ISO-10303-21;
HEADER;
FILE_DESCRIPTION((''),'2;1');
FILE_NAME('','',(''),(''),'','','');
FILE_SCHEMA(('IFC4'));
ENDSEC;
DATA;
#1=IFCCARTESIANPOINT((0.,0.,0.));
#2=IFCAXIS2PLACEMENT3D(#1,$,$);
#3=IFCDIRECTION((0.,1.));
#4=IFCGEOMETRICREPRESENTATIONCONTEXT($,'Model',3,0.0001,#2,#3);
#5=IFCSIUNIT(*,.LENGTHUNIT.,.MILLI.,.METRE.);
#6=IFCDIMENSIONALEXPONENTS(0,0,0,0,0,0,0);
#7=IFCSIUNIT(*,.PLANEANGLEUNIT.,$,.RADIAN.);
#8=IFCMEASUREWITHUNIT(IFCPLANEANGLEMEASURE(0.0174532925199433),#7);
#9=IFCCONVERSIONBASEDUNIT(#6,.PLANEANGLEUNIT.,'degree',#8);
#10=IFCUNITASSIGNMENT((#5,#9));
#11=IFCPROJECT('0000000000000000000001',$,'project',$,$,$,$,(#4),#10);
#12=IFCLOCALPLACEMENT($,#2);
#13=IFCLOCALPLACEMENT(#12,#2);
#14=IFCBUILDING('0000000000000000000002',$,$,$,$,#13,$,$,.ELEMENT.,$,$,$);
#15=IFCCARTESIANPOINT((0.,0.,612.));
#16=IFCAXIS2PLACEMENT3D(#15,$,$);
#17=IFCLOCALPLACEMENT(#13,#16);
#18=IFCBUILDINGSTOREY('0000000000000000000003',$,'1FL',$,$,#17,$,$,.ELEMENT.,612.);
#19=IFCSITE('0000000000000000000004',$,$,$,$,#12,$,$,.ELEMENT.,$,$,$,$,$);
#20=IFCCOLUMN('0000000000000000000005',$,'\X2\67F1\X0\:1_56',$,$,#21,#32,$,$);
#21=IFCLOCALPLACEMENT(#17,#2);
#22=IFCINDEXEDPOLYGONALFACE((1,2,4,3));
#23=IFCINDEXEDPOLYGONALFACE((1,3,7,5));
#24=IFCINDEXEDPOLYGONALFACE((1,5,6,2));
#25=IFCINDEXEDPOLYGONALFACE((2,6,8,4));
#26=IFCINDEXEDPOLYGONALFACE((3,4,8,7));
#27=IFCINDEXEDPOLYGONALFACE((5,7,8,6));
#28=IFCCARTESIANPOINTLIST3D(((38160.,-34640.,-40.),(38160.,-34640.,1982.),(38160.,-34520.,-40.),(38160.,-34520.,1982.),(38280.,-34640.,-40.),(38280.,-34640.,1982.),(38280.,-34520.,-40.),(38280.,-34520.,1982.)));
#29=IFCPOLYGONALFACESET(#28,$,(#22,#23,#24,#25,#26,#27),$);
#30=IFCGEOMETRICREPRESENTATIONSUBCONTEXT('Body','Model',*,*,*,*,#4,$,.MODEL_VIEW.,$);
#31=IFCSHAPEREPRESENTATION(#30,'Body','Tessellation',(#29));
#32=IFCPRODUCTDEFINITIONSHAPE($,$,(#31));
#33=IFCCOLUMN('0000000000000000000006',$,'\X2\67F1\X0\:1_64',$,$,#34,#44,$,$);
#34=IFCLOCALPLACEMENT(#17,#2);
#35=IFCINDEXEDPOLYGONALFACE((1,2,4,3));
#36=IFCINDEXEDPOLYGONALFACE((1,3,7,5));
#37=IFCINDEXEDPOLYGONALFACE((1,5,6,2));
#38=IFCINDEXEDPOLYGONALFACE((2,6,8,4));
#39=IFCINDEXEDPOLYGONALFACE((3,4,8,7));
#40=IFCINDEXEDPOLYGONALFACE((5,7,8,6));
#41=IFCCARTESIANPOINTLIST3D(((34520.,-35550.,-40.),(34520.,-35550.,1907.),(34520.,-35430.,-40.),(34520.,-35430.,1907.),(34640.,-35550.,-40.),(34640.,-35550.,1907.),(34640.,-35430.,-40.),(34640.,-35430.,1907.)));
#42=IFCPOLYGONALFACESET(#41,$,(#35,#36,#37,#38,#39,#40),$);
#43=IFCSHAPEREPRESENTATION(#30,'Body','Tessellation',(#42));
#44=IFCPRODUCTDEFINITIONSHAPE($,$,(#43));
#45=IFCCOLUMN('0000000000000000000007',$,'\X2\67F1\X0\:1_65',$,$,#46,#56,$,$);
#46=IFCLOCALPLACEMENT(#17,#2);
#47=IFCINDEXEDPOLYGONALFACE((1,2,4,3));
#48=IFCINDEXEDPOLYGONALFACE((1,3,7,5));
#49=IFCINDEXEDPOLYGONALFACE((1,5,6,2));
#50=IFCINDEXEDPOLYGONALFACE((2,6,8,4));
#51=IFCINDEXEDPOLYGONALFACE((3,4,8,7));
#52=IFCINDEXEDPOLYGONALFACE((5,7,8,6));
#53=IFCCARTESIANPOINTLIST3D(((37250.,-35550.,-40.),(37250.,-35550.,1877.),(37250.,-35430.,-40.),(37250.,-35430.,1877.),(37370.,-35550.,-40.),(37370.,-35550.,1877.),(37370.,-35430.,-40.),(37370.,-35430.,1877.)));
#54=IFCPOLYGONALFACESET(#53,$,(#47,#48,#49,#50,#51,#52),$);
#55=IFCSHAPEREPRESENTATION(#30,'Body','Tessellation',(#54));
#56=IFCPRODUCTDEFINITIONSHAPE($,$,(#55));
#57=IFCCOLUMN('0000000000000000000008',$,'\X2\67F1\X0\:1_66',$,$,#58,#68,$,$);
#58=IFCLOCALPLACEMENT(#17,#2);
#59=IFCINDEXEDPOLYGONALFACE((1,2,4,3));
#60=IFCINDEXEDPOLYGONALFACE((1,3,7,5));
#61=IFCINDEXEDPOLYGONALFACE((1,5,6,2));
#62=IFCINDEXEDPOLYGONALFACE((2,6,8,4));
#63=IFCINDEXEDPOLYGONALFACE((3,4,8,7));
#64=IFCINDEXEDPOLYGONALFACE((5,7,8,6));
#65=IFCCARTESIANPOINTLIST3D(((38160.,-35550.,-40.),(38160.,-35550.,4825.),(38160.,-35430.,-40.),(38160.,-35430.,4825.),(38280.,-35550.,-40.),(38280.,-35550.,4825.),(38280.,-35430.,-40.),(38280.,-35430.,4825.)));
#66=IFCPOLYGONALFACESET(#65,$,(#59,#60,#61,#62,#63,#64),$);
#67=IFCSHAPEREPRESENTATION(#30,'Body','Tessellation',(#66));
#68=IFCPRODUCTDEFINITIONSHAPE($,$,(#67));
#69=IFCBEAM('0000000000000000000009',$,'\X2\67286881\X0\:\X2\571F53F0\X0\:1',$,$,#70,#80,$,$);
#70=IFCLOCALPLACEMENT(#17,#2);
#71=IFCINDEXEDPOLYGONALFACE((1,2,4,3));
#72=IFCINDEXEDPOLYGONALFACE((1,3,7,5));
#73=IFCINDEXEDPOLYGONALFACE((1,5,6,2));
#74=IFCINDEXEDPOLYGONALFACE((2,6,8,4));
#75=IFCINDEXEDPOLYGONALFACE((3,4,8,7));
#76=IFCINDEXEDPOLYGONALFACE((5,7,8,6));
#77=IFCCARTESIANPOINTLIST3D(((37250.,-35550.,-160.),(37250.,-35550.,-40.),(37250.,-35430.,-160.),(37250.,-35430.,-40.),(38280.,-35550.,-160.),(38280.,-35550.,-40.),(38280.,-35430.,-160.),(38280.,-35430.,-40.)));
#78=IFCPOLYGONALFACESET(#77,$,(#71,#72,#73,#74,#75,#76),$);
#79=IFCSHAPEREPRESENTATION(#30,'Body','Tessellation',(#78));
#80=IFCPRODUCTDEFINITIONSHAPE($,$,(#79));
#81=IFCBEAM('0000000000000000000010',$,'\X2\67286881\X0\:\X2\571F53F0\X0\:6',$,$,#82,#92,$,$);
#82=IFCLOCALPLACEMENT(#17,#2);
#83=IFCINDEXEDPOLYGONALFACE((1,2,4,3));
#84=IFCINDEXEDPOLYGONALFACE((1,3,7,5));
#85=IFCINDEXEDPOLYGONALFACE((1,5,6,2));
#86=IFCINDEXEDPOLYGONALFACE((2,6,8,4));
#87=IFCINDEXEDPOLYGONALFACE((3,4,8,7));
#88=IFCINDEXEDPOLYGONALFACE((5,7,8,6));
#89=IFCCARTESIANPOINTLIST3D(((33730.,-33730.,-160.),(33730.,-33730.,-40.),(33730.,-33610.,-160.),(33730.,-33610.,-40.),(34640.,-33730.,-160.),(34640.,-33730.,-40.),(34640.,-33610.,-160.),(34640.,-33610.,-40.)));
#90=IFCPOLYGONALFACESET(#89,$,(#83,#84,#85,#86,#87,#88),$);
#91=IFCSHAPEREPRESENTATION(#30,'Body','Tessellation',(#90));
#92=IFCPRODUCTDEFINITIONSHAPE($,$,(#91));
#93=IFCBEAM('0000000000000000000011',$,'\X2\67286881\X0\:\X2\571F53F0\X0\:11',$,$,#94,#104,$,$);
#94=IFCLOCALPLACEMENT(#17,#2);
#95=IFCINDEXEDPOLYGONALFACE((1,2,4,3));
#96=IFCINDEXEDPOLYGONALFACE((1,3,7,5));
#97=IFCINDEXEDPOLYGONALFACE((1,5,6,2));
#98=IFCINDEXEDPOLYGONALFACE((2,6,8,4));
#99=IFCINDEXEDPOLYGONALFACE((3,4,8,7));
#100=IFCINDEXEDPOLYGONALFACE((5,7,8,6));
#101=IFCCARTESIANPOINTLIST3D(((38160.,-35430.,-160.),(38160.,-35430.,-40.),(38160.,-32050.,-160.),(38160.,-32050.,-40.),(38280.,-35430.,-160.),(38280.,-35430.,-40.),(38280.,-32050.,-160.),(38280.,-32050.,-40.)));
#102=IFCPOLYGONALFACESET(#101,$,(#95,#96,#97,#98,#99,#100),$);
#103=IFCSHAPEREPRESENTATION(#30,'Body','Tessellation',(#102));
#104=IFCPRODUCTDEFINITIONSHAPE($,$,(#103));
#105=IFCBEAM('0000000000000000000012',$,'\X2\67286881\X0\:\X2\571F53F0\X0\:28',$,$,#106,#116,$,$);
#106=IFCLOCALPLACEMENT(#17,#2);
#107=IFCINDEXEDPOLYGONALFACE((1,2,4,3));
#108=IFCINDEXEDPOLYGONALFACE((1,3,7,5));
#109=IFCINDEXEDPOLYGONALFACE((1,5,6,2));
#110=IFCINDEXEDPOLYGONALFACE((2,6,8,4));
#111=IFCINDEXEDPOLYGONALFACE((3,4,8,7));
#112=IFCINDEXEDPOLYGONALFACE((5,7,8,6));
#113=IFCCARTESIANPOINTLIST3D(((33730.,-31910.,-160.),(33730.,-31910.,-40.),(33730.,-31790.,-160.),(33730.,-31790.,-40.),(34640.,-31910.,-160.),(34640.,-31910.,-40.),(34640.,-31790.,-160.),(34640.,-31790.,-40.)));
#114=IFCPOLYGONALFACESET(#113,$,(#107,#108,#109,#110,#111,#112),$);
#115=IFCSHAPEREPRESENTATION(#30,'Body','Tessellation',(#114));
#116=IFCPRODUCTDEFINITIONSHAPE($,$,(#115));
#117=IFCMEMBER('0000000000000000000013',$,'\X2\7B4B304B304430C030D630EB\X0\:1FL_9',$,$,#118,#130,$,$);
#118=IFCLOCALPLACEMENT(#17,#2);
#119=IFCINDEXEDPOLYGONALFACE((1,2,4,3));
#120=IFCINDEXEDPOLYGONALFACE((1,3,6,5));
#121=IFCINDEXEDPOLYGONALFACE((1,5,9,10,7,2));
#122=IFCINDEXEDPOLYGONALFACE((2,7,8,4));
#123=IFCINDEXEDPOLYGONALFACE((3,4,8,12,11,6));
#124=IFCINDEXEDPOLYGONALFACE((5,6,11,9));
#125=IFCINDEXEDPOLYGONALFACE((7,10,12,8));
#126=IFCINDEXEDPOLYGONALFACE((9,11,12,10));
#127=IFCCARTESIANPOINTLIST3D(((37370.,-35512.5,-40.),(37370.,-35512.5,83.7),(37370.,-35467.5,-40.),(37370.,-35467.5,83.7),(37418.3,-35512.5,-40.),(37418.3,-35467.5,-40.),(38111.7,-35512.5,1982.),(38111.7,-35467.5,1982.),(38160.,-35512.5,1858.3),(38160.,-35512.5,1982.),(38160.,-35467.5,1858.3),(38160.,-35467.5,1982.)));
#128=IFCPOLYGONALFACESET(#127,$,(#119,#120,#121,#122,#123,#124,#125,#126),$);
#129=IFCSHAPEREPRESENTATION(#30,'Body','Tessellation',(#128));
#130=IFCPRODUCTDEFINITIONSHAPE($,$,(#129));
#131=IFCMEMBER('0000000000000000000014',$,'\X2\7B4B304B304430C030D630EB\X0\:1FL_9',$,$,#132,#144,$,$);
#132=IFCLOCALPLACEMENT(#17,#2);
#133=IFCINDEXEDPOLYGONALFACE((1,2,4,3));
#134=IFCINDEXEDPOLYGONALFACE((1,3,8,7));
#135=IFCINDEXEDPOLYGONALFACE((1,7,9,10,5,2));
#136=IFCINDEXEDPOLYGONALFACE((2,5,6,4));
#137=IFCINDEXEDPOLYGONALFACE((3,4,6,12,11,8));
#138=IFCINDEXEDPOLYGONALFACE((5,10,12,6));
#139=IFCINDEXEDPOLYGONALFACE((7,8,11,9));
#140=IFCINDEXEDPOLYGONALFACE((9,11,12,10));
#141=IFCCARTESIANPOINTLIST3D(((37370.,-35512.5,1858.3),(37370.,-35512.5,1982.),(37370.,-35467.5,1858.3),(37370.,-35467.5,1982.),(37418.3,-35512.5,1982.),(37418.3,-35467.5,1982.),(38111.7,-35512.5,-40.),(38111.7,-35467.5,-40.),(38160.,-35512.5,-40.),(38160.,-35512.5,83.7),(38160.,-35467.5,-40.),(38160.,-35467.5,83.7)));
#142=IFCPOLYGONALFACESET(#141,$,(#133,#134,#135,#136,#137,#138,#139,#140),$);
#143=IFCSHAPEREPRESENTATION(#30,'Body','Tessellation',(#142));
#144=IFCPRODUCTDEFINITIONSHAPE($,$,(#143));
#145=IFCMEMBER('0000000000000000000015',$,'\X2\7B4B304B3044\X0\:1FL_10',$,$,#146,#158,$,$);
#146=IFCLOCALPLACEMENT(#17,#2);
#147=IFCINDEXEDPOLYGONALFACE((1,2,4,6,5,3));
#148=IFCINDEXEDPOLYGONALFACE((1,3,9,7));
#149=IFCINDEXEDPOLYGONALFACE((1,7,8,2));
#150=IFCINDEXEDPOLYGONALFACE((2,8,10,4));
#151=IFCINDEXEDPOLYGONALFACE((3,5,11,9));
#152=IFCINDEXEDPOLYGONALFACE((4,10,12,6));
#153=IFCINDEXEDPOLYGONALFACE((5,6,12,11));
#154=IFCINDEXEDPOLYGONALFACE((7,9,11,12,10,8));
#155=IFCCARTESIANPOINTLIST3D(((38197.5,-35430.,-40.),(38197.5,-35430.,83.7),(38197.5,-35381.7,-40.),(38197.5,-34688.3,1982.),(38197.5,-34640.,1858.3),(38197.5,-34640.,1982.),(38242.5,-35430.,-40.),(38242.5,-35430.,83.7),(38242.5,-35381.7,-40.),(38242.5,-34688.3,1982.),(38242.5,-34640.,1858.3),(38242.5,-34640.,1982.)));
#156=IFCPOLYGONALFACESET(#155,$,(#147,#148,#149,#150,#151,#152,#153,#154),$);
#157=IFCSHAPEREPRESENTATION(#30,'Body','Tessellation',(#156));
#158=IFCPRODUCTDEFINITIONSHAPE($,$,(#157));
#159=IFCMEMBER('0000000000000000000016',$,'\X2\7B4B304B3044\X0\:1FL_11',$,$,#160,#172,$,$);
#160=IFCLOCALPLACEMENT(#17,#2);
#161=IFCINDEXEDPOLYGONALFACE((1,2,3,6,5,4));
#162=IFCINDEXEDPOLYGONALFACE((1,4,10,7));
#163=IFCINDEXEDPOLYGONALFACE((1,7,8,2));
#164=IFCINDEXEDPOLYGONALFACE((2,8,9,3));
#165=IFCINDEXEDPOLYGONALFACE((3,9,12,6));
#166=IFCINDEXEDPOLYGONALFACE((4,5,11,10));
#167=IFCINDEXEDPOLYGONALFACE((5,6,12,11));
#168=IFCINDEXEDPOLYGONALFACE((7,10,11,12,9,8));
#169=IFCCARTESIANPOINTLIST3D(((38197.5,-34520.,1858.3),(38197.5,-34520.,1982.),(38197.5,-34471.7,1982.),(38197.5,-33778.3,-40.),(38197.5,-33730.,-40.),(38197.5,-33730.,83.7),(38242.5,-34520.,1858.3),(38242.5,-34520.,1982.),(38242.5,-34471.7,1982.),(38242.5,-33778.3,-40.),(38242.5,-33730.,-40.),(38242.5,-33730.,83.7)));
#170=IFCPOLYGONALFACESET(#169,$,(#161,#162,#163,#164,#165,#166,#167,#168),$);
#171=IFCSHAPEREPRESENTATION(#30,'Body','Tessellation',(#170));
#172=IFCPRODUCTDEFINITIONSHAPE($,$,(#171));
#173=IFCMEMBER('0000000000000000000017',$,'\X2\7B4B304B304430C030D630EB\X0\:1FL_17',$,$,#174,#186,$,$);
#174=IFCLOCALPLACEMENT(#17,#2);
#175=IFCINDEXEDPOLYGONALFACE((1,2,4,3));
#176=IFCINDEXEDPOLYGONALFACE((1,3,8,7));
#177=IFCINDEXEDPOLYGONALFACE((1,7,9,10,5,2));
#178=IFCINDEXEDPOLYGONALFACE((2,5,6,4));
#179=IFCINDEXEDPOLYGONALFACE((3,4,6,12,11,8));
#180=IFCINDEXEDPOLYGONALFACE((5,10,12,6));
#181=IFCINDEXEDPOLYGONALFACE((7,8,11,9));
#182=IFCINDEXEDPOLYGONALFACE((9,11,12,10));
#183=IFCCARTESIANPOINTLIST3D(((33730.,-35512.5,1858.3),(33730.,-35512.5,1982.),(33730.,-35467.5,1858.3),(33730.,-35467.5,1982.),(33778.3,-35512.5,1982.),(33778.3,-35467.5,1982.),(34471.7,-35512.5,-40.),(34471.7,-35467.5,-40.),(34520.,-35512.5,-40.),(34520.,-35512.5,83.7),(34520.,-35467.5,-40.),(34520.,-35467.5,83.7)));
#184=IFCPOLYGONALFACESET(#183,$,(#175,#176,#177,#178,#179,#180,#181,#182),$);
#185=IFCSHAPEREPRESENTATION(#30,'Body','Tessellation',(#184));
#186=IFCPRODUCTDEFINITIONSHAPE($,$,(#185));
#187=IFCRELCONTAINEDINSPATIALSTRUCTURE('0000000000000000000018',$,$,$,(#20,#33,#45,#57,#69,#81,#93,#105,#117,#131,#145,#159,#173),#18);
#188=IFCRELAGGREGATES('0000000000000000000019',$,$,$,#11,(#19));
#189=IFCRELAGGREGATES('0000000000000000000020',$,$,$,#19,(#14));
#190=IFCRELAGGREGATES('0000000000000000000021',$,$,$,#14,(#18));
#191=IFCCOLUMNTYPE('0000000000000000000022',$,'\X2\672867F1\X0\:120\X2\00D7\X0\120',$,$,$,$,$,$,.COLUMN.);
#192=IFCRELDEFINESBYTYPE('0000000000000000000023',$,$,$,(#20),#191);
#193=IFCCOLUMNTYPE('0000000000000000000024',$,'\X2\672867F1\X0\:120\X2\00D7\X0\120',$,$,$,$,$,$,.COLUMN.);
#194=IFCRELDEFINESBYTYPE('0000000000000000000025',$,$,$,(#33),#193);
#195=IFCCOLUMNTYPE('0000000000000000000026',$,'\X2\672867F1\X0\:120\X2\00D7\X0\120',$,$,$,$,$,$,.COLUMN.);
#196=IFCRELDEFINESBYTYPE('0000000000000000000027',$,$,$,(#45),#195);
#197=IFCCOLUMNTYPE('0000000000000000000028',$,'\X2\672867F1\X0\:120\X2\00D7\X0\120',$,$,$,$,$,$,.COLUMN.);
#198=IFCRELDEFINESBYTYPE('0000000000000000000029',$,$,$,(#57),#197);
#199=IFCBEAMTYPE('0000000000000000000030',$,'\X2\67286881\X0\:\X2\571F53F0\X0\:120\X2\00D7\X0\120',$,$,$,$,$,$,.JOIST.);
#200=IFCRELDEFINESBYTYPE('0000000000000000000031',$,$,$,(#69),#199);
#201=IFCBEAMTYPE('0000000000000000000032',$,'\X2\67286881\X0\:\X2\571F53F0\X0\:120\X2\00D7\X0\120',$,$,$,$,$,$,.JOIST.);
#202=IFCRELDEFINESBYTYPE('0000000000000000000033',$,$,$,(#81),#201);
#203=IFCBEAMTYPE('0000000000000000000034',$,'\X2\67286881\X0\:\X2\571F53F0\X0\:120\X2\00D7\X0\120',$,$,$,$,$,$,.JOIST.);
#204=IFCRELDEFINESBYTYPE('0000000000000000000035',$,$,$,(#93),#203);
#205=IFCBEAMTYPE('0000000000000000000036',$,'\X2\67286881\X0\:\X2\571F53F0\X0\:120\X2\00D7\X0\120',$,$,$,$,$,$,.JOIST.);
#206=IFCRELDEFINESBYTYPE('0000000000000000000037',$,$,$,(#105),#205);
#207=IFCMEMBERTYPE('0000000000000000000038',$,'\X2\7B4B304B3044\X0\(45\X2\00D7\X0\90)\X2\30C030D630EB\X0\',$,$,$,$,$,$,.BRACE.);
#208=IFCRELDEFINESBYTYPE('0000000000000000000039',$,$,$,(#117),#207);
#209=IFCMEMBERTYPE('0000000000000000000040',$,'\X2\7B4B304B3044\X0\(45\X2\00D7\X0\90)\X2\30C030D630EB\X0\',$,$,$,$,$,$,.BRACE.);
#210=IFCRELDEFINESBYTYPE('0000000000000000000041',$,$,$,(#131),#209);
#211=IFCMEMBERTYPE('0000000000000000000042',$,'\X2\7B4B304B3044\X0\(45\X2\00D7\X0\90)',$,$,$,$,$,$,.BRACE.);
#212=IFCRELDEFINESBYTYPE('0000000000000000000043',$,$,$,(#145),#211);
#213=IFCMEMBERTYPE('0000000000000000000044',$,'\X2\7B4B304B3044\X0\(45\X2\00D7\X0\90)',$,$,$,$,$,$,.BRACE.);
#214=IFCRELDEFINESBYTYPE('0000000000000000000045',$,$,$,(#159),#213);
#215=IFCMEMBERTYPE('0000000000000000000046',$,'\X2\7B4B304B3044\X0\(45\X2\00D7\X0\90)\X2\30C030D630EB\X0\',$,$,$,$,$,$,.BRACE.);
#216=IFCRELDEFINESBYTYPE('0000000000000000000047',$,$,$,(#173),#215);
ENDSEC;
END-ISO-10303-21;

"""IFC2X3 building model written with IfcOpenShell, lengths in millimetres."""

from ifc_helpers import new_model, entity, si_unit, converted_unit, direction, frame, origin, origin_with_axes, origin_2d, place, context, subcontext, project, spatial, polyline, rectangle, outline, extrude, type_object, element, save


model = new_model("IFC2X3")

# Units and contexts
model_context = context("Model", 3, precision=0.0001, world=origin(), true_north=direction((0.0, 1.0)))
body_context = subcontext(model_context, "Body", "Model", "MODEL_VIEW")
ifc_project = project(units=[si_unit("LENGTHUNIT", "METRE", prefix="MILLI"), converted_unit("PLANEANGLEUNIT", "degree", entity("IfcPlaneAngleMeasure", 0.0174532925199433), si_unit("PLANEANGLEUNIT", "RADIAN"), dimensions=[0, 0, 0, 0, 0, 0, 0])], contexts=[model_context])

# Site, building, storey
site_placement = place(None, origin())
site = spatial("IfcSite", under=ifc_project, at=site_placement, CompositionType="ELEMENT")
building_placement = place(site_placement, origin())
building = spatial("IfcBuilding", under=site, at=building_placement, CompositionType="ELEMENT")
storey_placement = place(building_placement, frame((0.0, 0.0, 612.0)))
storey = spatial("IfcBuildingStorey", under=building, at=storey_placement, Name="1FL", CompositionType="ELEMENT", Elevation=612.0)

# Columns
column_type_1 = type_object("IfcColumnType", Name="木柱:120×120", PredefinedType="COLUMN")
column_1_placement = place(storey_placement, frame((38220.0, -34580.0, -40.0)))
element("IfcColumn", 1, at=column_1_placement, inside=storey, type_object=column_type_1, Name="柱:1_56", context=body_context, shape_type="SweptSolid", body=[
    extrude(rectangle(XDim=120.0, YDim=120.0, at=origin_2d()), origin_with_axes(), (0.0, 0.0, 1.0), 2022.0),
])
column_type_2 = type_object("IfcColumnType", Name="木柱:120×120", PredefinedType="COLUMN")
column_2_placement = place(storey_placement, frame((34580.0, -35490.0, -40.0)))
element("IfcColumn", 2, at=column_2_placement, inside=storey, type_object=column_type_2, Name="柱:1_64", context=body_context, shape_type="SweptSolid", body=[
    extrude(rectangle(XDim=120.0, YDim=120.0, at=origin_2d()), origin_with_axes(), (0.0, 0.0, 1.0), 1947.0),
])
column_type_3 = type_object("IfcColumnType", Name="木柱:120×120", PredefinedType="COLUMN")
column_3_placement = place(storey_placement, frame((37310.0, -35490.0, -40.0)))
element("IfcColumn", 3, at=column_3_placement, inside=storey, type_object=column_type_3, Name="柱:1_65", context=body_context, shape_type="SweptSolid", body=[
    extrude(rectangle(XDim=120.0, YDim=120.0, at=origin_2d()), origin_with_axes(), (0.0, 0.0, 1.0), 1917.0),
])
column_type_4 = type_object("IfcColumnType", Name="木柱:120×120", PredefinedType="COLUMN")
column_4_placement = place(storey_placement, frame((38220.0, -35490.0, -40.0)))
element("IfcColumn", 4, at=column_4_placement, inside=storey, type_object=column_type_4, Name="柱:1_66", context=body_context, shape_type="SweptSolid", body=[
    extrude(rectangle(XDim=120.0, YDim=120.0, at=origin_2d()), origin_with_axes(), (0.0, 0.0, 1.0), 4865.0),
])

# Beams
beam_type_1 = type_object("IfcBeamType", Name="木梁:土台:120×120", PredefinedType="JOIST")
beam_1_placement = place(storey_placement, frame((37250.0, -35490.0, -100.0), z_axis=(1.0, 0.0, 0.0), x_axis=(0.0, 1.0, 0.0)))
element("IfcBeam", 5, at=beam_1_placement, inside=storey, type_object=beam_type_1, Name="木梁:土台:1", context=body_context, shape_type="SweptSolid", body=[
    extrude(rectangle(XDim=120.0, YDim=120.0, at=origin_2d()), origin_with_axes(), (0.0, 0.0, 1.0), 1030.0),
])
beam_type_2 = type_object("IfcBeamType", Name="木梁:土台:120×120", PredefinedType="JOIST")
beam_2_placement = place(storey_placement, frame((33730.0, -33670.0, -100.0), z_axis=(1.0, 0.0, 0.0), x_axis=(0.0, 1.0, 0.0)))
element("IfcBeam", 6, at=beam_2_placement, inside=storey, type_object=beam_type_2, Name="木梁:土台:6", context=body_context, shape_type="SweptSolid", body=[
    extrude(rectangle(XDim=120.0, YDim=120.0, at=origin_2d()), origin_with_axes(), (0.0, 0.0, 1.0), 910.0),
])
beam_type_3 = type_object("IfcBeamType", Name="木梁:土台:120×120", PredefinedType="JOIST")
beam_3_placement = place(storey_placement, frame((38220.0, -32050.0, -100.0), z_axis=(0.0, -1.0, 0.0), x_axis=(1.0, 0.0, 0.0)))
element("IfcBeam", 7, at=beam_3_placement, inside=storey, type_object=beam_type_3, Name="木梁:土台:11", context=body_context, shape_type="SweptSolid", body=[
    extrude(rectangle(XDim=120.0, YDim=120.0, at=origin_2d()), origin_with_axes(), (0.0, 0.0, 1.0), 3380.0),
])
beam_type_4 = type_object("IfcBeamType", Name="木梁:土台:120×120", PredefinedType="JOIST")
beam_4_placement = place(storey_placement, frame((33730.0, -31850.0, -100.0), z_axis=(1.0, 0.0, 0.0), x_axis=(0.0, 1.0, 0.0)))
element("IfcBeam", 8, at=beam_4_placement, inside=storey, type_object=beam_type_4, Name="木梁:土台:28", context=body_context, shape_type="SweptSolid", body=[
    extrude(rectangle(XDim=120.0, YDim=120.0, at=origin_2d()), origin_with_axes(), (0.0, 0.0, 1.0), 910.0),
])

# Members
member_type_1 = type_object("IfcMemberType", Name="筋かい(45×90)ダブル", PredefinedType="BRACE")
member_1_placement = place(storey_placement, frame((37370.0, -35490.0, -40.0), z_axis=(0.363913, 0.0, 0.931433), x_axis=(-0.931433, 0.0, 0.363913)))
element("IfcMember", 9, at=member_1_placement, inside=storey, type_object=member_type_1, Name="筋かいダブル:1FL_9", context=body_context, shape_type="SweptSolid", body=[
    extrude(outline(polyline([(0.0, 0.0), (17.6, -45.0), (2055.7, -45.0), (2170.8, 0.0), (2153.3, 45.0), (115.2, 45.0), (0.0, 0.0)])), frame((0.0, -22.5, 0.0), z_axis=(0.0, 1.0, 0.0), x_axis=(0.0, 0.0, 1.0)), (0.0, 0.0, 1.0), 45.0),
])
member_type_2 = type_object("IfcMemberType", Name="筋かい(45×90)ダブル", PredefinedType="BRACE")
member_2_placement = place(storey_placement, frame((38160.0, -35490.0, -40.0), z_axis=(-0.363913, 0.0, 0.931433), x_axis=(0.931433, 0.0, 0.363913)))
element("IfcMember", 10, at=member_2_placement, inside=storey, type_object=member_type_2, Name="筋かいダブル:1FL_9", context=body_context, shape_type="SweptSolid", body=[
    extrude(outline(polyline([(0.0, 0.0), (17.6, -45.0), (2055.7, -45.0), (2170.8, 0.0), (2153.3, 45.0), (115.2, 45.0), (0.0, 0.0)])), frame((0.0, -22.5, 0.0), z_axis=(0.0, 1.0, 0.0), x_axis=(0.0, 0.0, 1.0)), (0.0, 0.0, 1.0), 45.0),
])
member_type_3 = type_object("IfcMemberType", Name="筋かい(45×90)", PredefinedType="BRACE")
member_3_placement = place(storey_placement, frame((38220.0, -35430.0, -40.0), z_axis=(0.0, 0.363913, 0.931433), x_axis=(0.0, -0.931433, 0.363913)))
element("IfcMember", 11, at=member_3_placement, inside=storey, type_object=member_type_3, Name="筋かい:1FL_10", context=body_context, shape_type="SweptSolid", body=[
    extrude(outline(polyline([(0.0, 0.0), (17.6, -45.0), (2055.7, -45.0), (2170.8, 0.0), (2153.3, 45.0), (115.2, 45.0), (0.0, 0.0)])), frame((0.0, -22.5, 0.0), z_axis=(0.0, 1.0, 0.0), x_axis=(0.0, 0.0, 1.0)), (0.0, 0.0, 1.0), 45.0),
])
member_type_4 = type_object("IfcMemberType", Name="筋かい(45×90)", PredefinedType="BRACE")
member_4_placement = place(storey_placement, frame((38220.0, -33730.0, -40.0), z_axis=(0.0, -0.363913, 0.931433), x_axis=(0.0, 0.931433, 0.363913)))
element("IfcMember", 12, at=member_4_placement, inside=storey, type_object=member_type_4, Name="筋かい:1FL_11", context=body_context, shape_type="SweptSolid", body=[
    extrude(outline(polyline([(0.0, 0.0), (17.6, -45.0), (2055.7, -45.0), (2170.8, 0.0), (2153.3, 45.0), (115.2, 45.0), (0.0, 0.0)])), frame((0.0, -22.5, 0.0), z_axis=(0.0, 1.0, 0.0), x_axis=(0.0, 0.0, 1.0)), (0.0, 0.0, 1.0), 45.0),
])
member_type_5 = type_object("IfcMemberType", Name="筋かい(45×90)ダブル", PredefinedType="BRACE")
member_5_placement = place(storey_placement, frame((34520.0, -35490.0, -40.0), z_axis=(-0.363913, 0.0, 0.931433), x_axis=(0.931433, 0.0, 0.363913)))
element("IfcMember", 13, at=member_5_placement, inside=storey, type_object=member_type_5, Name="筋かいダブル:1FL_17", context=body_context, shape_type="SweptSolid", body=[
    extrude(outline(polyline([(0.0, 0.0), (17.6, -45.0), (2055.7, -45.0), (2170.8, 0.0), (2153.3, 45.0), (115.2, 45.0), (0.0, 0.0)])), frame((0.0, -22.5, 0.0), z_axis=(0.0, 1.0, 0.0), x_axis=(0.0, 0.0, 1.0)), (0.0, 0.0, 1.0), 45.0),
])

save(model, "model.ifc")
